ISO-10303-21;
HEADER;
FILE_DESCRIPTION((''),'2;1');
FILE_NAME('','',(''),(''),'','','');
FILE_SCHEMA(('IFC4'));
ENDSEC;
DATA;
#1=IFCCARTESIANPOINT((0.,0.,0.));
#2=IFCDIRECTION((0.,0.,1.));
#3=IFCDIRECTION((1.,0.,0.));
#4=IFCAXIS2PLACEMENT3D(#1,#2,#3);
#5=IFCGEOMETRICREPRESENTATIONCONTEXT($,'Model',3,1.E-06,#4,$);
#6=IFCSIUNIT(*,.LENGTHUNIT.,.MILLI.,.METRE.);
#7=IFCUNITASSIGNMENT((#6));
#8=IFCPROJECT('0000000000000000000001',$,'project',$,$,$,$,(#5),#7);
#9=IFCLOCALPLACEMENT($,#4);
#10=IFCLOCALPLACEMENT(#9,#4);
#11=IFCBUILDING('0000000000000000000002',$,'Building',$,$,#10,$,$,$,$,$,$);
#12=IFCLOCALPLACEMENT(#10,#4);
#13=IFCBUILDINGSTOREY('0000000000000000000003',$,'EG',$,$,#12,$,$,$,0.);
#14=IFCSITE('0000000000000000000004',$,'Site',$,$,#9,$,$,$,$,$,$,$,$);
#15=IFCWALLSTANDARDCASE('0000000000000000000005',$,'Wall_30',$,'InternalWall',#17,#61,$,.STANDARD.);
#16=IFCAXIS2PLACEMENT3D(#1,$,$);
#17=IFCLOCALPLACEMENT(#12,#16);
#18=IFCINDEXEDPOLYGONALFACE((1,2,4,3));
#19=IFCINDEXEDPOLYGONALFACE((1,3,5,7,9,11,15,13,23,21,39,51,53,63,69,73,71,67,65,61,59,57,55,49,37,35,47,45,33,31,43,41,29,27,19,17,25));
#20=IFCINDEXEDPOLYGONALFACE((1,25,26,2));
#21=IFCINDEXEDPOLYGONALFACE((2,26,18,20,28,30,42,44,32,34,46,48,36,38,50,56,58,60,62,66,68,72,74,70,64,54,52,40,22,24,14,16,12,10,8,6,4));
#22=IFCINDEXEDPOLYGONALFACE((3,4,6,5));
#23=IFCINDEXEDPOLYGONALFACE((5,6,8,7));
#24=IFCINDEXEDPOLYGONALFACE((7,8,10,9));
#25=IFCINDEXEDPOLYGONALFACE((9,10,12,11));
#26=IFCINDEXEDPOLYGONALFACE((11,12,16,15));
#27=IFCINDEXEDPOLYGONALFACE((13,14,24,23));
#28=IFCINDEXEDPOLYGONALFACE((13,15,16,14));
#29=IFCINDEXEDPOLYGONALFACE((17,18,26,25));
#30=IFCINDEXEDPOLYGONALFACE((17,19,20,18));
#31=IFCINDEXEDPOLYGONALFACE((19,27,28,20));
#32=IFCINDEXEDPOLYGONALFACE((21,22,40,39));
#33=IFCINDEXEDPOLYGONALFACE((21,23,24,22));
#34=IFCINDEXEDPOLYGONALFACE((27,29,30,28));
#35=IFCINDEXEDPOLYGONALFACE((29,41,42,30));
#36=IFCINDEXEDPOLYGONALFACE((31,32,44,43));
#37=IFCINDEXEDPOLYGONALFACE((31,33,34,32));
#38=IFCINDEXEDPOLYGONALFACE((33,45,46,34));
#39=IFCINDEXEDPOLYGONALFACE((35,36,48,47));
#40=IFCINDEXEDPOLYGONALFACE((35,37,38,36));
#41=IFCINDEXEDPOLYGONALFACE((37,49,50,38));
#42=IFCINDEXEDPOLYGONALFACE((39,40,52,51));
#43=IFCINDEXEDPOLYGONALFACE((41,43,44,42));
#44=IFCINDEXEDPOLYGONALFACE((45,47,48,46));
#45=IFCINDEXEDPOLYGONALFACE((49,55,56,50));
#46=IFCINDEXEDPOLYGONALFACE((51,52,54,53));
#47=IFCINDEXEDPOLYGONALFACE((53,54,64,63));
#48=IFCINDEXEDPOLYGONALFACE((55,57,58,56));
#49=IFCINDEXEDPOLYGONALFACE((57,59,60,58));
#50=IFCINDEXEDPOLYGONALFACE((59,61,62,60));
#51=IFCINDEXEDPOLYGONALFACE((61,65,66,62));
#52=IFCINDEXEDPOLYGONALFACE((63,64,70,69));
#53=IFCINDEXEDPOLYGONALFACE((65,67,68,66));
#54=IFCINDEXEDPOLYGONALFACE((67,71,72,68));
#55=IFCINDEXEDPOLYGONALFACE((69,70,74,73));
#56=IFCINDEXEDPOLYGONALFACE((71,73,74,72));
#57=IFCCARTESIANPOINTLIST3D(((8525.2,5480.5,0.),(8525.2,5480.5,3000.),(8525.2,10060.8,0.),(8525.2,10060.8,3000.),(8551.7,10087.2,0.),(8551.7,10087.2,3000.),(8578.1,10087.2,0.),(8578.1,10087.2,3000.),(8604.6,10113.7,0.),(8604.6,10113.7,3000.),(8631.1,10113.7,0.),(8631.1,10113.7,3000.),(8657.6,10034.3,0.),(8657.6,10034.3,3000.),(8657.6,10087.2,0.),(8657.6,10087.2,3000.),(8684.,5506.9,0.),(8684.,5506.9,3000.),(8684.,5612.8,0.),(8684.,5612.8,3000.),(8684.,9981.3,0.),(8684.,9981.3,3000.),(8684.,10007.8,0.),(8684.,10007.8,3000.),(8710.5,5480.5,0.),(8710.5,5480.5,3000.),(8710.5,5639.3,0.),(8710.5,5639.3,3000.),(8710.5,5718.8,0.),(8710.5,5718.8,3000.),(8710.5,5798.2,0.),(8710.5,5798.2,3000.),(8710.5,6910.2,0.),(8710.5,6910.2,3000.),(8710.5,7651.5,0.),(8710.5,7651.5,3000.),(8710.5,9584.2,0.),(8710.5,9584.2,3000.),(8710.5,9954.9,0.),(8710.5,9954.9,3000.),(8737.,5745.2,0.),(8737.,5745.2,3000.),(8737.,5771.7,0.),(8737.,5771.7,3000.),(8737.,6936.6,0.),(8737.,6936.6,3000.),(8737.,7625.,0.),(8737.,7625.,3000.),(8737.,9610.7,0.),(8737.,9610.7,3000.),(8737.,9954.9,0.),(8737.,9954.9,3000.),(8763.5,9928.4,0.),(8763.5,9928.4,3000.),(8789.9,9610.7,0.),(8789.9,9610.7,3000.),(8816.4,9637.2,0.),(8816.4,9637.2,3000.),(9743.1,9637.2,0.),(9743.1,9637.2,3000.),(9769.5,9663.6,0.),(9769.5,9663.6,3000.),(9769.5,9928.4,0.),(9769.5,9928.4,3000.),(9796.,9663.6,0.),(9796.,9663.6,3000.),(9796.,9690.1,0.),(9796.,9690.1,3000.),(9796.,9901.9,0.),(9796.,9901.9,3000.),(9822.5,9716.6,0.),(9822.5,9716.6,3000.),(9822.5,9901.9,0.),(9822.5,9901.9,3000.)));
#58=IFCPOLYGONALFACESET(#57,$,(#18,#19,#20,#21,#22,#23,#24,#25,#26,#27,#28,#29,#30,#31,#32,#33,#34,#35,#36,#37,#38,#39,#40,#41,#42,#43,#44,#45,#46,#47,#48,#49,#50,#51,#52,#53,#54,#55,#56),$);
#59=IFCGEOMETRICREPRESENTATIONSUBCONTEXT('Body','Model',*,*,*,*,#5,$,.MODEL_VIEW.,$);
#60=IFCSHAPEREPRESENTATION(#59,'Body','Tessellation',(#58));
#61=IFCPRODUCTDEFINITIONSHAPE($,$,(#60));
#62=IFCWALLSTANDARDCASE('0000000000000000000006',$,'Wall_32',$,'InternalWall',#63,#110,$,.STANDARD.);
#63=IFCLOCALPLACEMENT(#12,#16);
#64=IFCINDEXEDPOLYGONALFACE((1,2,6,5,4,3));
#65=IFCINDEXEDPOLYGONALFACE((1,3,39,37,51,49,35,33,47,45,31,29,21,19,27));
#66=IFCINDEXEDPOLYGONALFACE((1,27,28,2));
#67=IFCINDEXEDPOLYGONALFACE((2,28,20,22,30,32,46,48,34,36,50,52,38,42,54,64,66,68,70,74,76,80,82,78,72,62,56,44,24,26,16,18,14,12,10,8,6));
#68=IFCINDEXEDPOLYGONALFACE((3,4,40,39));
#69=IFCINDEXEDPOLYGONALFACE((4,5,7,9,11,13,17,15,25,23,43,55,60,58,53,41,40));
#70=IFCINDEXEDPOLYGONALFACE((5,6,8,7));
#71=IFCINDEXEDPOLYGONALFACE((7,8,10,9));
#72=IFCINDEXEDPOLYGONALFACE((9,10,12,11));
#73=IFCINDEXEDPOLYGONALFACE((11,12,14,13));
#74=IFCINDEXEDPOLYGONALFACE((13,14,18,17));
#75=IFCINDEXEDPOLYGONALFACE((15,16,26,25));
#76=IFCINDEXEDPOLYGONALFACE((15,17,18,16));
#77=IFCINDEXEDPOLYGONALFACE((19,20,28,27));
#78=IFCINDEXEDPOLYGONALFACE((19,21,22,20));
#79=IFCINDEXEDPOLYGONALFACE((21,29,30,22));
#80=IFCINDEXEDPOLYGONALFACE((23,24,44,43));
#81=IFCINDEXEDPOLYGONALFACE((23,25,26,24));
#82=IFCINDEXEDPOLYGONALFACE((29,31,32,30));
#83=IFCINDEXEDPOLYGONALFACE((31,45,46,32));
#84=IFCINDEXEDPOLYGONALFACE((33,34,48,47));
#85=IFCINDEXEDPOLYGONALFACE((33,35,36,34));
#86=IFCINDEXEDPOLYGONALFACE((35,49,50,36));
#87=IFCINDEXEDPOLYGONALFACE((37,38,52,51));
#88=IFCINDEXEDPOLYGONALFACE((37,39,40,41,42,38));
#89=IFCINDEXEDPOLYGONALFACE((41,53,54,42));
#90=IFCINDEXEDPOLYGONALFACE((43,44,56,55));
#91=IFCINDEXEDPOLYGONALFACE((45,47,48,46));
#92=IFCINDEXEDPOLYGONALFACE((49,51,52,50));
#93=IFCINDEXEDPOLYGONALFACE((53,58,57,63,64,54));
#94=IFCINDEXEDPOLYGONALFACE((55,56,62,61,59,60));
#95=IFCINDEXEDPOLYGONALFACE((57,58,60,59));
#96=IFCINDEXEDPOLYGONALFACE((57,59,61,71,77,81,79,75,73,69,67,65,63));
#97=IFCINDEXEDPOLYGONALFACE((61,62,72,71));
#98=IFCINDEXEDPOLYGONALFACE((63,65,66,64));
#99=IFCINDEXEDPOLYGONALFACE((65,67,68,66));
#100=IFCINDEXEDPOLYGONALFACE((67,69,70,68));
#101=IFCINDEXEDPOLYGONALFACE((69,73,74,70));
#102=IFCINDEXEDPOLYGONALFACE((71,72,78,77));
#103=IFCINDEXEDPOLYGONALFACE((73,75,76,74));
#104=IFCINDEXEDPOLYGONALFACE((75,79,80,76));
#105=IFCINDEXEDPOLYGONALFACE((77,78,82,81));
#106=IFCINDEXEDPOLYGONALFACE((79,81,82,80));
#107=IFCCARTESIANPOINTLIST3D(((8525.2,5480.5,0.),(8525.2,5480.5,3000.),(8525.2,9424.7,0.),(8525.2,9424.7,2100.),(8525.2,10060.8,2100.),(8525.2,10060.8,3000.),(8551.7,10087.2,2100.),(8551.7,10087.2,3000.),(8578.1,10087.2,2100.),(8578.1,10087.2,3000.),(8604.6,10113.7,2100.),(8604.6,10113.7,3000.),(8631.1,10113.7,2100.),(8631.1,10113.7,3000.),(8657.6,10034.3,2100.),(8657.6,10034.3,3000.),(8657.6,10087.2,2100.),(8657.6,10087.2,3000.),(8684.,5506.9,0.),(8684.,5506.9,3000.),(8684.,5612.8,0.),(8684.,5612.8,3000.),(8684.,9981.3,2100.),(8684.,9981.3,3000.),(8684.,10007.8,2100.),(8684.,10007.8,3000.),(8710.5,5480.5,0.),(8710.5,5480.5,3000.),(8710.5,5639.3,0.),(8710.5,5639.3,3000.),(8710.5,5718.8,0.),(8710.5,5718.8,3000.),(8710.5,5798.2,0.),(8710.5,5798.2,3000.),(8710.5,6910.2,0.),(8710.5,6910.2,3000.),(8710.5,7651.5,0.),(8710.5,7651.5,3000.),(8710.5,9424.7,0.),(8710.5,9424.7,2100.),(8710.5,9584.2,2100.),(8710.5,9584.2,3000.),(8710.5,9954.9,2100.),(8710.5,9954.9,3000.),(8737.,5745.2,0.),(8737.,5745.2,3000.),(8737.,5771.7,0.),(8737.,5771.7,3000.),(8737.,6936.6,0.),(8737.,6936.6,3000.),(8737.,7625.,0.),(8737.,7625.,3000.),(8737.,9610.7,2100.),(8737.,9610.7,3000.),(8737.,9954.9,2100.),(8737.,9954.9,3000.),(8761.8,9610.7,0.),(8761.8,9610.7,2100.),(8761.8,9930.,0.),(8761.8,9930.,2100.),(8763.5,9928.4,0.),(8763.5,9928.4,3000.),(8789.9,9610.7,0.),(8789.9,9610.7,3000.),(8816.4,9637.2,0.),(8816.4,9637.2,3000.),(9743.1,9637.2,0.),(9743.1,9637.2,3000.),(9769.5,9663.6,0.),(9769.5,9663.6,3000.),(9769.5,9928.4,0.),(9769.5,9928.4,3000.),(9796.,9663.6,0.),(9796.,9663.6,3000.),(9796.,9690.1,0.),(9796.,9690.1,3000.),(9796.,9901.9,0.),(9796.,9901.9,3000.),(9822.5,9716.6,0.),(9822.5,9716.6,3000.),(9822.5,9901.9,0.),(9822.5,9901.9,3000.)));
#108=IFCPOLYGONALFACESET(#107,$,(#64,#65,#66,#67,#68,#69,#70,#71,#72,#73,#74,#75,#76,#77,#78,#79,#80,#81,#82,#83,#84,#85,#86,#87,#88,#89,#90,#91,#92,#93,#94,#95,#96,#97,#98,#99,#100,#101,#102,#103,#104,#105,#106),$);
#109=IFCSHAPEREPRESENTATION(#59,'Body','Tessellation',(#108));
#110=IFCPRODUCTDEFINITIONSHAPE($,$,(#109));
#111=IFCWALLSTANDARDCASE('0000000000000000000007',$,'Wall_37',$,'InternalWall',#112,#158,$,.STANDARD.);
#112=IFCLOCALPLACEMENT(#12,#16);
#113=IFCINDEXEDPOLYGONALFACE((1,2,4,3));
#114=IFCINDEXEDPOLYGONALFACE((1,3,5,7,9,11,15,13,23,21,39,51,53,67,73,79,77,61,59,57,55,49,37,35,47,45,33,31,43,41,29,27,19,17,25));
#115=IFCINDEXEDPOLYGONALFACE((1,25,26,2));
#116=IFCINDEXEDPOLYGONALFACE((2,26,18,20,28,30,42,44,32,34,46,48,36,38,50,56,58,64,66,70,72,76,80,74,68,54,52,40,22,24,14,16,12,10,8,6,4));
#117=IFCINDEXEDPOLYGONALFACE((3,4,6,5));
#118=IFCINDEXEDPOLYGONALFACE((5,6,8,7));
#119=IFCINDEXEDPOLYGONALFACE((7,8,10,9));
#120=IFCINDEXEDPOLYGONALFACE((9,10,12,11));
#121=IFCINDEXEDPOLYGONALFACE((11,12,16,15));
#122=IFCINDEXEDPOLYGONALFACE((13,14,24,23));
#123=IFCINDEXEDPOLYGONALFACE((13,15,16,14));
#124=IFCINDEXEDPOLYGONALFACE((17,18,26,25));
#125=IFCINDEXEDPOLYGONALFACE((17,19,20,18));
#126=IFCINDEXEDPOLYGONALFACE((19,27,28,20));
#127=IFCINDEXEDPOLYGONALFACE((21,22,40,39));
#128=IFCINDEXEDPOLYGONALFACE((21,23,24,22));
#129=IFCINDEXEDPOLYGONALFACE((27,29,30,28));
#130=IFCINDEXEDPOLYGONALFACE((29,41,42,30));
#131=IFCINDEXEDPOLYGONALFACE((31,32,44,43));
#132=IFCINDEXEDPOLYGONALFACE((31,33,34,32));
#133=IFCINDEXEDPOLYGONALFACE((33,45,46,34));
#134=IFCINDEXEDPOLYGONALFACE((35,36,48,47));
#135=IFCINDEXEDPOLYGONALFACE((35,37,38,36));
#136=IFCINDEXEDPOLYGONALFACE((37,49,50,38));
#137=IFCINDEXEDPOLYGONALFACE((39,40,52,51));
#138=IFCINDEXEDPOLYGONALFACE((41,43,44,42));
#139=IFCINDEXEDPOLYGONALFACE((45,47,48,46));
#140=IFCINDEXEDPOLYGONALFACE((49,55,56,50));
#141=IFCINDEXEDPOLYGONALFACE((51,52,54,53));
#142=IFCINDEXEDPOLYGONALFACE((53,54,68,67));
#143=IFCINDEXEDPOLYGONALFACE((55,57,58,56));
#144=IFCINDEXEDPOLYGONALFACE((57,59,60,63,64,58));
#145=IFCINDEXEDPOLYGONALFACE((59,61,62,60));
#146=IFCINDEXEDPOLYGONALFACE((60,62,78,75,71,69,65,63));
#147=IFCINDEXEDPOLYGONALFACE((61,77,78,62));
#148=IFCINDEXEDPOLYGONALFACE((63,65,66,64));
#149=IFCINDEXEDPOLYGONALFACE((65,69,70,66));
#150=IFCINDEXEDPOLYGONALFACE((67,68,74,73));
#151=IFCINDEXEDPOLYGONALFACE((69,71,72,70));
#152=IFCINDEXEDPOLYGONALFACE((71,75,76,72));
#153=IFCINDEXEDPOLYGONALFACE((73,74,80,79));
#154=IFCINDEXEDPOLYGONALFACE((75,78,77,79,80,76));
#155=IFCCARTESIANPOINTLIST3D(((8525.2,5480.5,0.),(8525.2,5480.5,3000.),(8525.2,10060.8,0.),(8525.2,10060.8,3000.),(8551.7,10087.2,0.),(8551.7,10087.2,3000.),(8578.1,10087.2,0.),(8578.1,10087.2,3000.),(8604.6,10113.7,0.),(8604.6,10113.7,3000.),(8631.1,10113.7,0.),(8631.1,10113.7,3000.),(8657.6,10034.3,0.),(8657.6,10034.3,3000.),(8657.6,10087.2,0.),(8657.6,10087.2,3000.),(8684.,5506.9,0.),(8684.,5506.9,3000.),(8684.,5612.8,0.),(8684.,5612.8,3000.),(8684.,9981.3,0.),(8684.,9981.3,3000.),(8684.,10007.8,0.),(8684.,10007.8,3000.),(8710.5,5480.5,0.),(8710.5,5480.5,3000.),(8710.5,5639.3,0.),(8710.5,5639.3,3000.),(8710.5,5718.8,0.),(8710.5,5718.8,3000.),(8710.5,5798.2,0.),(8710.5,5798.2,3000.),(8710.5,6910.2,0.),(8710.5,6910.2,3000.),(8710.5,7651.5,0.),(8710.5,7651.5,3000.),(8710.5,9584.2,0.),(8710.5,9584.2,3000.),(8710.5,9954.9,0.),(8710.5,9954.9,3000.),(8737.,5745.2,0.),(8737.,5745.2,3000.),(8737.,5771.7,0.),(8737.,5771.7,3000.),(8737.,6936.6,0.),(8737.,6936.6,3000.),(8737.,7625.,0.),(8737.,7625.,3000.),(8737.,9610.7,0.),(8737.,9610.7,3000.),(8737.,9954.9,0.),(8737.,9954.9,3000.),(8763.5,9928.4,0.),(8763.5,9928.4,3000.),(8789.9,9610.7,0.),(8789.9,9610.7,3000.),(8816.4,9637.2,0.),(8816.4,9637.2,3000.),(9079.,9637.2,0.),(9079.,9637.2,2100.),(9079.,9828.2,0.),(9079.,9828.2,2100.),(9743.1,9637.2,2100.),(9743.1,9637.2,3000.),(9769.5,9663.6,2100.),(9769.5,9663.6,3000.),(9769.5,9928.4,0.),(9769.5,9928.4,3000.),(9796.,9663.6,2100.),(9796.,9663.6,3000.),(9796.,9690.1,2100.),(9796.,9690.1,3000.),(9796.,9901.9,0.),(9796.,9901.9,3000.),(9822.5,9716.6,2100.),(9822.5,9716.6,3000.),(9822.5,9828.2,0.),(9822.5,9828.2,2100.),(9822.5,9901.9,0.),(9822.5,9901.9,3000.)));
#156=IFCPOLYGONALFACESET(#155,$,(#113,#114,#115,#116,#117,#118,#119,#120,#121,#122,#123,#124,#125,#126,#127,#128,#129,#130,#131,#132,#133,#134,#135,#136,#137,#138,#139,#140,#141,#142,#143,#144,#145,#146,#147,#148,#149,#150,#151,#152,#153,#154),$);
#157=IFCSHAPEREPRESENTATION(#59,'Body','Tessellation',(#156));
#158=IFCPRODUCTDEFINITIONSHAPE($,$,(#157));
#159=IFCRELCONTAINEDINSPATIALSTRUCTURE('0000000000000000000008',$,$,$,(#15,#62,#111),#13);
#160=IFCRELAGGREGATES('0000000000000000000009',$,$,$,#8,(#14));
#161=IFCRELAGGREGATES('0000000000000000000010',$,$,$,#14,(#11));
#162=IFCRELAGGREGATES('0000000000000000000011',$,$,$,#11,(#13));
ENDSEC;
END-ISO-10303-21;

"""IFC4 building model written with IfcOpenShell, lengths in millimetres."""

from ifc_helpers import new_model, si_unit, frame, origin_with_axes, place, context, subcontext, project, spatial, polyline, rectangle, outline, extrude, element, save


model = new_model("IFC4")

# Units and contexts
model_context = context("Model", 3, precision=1e-06, world=origin_with_axes())
body_context = subcontext(model_context, "Body", "Model", "MODEL_VIEW")
ifc_project = project(units=[si_unit("LENGTHUNIT", "METRE", prefix="MILLI")], contexts=[model_context])

# Site, building, storey
site_placement = place(None, origin_with_axes())
site = spatial("IfcSite", under=ifc_project, at=site_placement, Name="Site")
building_placement = place(site_placement, origin_with_axes())
building = spatial("IfcBuilding", under=site, at=building_placement, Name="Building")
storey_placement = place(building_placement, origin_with_axes())
storey = spatial("IfcBuildingStorey", under=building, at=storey_placement, Name="EG", Elevation=0.0)

# Wall
for number, where, z_axis, x_axis, name in (
    (1, (0.0, 0.0, 0.0), (0.0, 0.0, 1.0), (1.0, 0.0, 0.0), "Wall_30"),
):
    element("IfcWallStandardCase", number, at=place(storey_placement, frame(where, z_axis=z_axis, x_axis=x_axis)), inside=storey, Name=name, ObjectType="InternalWall", PredefinedType="STANDARD", context=body_context, shape_type="SweptSolid", body=[
        extrude(outline(polyline([(8525.2, 5480.5, 0.0), (8525.2, 10060.8, 0.0), (8551.7, 10087.2, 0.0), (8578.1, 10087.2, 0.0), (8604.6, 10113.7, 0.0), (8631.1, 10113.7, 0.0), (8657.6, 10087.2, 0.0), (8657.6, 10034.3, 0.0), (8684.0, 10007.8, 0.0), (8684.0, 9981.3, 0.0), (8710.5, 9954.9, 0.0), (8737.0, 9954.9, 0.0), (8763.5, 9928.4, 0.0), (9769.5, 9928.4, 0.0), (9796.0, 9901.9, 0.0), (9822.5, 9901.9, 0.0), (9822.5, 9716.6, 0.0), (9796.0, 9690.1, 0.0), (9796.0, 9663.6, 0.0), (9769.5, 9663.6, 0.0), (9743.1, 9637.2, 0.0), (8816.4, 9637.2, 0.0), (8789.9, 9610.7, 0.0), (8737.0, 9610.7, 0.0), (8710.5, 9584.2, 0.0), (8710.5, 7651.5, 0.0), (8737.0, 7625.0, 0.0), (8737.0, 6936.6, 0.0), (8710.5, 6910.2, 0.0), (8710.5, 5798.2, 0.0), (8737.0, 5771.7, 0.0), (8737.0, 5745.2, 0.0), (8710.5, 5718.8, 0.0), (8710.5, 5639.3, 0.0), (8684.0, 5612.8, 0.0), (8684.0, 5506.9, 0.0), (8710.5, 5480.5, 0.0), (8525.2, 5480.5, 0.0)])), origin_with_axes(), (0.0, 0.0, 1.0), 3000.0),
    ])

# Wall, opening
wall_1_placement = place(storey_placement, origin_with_axes())
wall_1 = element("IfcWallStandardCase", 2, at=wall_1_placement, inside=storey, Name="Wall_32", ObjectType="InternalWall", PredefinedType="STANDARD", context=body_context, shape_type="SweptSolid", body=[
    extrude(outline(polyline([(8525.2, 5480.5, 0.0), (8525.2, 10060.8, 0.0), (8551.7, 10087.2, 0.0), (8578.1, 10087.2, 0.0), (8604.6, 10113.7, 0.0), (8631.1, 10113.7, 0.0), (8657.6, 10087.2, 0.0), (8657.6, 10034.3, 0.0), (8684.0, 10007.8, 0.0), (8684.0, 9981.3, 0.0), (8710.5, 9954.9, 0.0), (8737.0, 9954.9, 0.0), (8763.5, 9928.4, 0.0), (9769.5, 9928.4, 0.0), (9796.0, 9901.9, 0.0), (9822.5, 9901.9, 0.0), (9822.5, 9716.6, 0.0), (9796.0, 9690.1, 0.0), (9796.0, 9663.6, 0.0), (9769.5, 9663.6, 0.0), (9743.1, 9637.2, 0.0), (8816.4, 9637.2, 0.0), (8789.9, 9610.7, 0.0), (8737.0, 9610.7, 0.0), (8710.5, 9584.2, 0.0), (8710.5, 7651.5, 0.0), (8737.0, 7625.0, 0.0), (8737.0, 6936.6, 0.0), (8710.5, 6910.2, 0.0), (8710.5, 5798.2, 0.0), (8737.0, 5771.7, 0.0), (8737.0, 5745.2, 0.0), (8710.5, 5718.8, 0.0), (8710.5, 5639.3, 0.0), (8684.0, 5612.8, 0.0), (8684.0, 5506.9, 0.0), (8710.5, 5480.5, 0.0), (8525.2, 5480.5, 0.0)])), origin_with_axes(), (0.0, 0.0, 1.0), 3000.0),
])
opening_1_placement = place(wall_1_placement, origin_with_axes())
element("IfcOpeningElement", 3, at=opening_1_placement, inside=storey, cuts=wall_1, context=body_context, shape_type="SweptSolid", body=[
    extrude(rectangle(XDim=1344.8, YDim=240.0), frame((8641.8, 10097.1, 0.0), z_axis=(0.0, 0.0, 1.0), x_axis=(0.0, 1.0, 0.0)), (0.0, 0.0, 1.0), 2100.0),
])

# Wall, opening
wall_2_placement = place(storey_placement, origin_with_axes())
wall_2 = element("IfcWallStandardCase", 4, at=wall_2_placement, inside=storey, Name="Wall_37", ObjectType="InternalWall", PredefinedType="STANDARD", context=body_context, shape_type="SweptSolid", body=[
    extrude(outline(polyline([(8525.2, 5480.5, 0.0), (8525.2, 10060.8, 0.0), (8551.7, 10087.2, 0.0), (8578.1, 10087.2, 0.0), (8604.6, 10113.7, 0.0), (8631.1, 10113.7, 0.0), (8657.6, 10087.2, 0.0), (8657.6, 10034.3, 0.0), (8684.0, 10007.8, 0.0), (8684.0, 9981.3, 0.0), (8710.5, 9954.9, 0.0), (8737.0, 9954.9, 0.0), (8763.5, 9928.4, 0.0), (9769.5, 9928.4, 0.0), (9796.0, 9901.9, 0.0), (9822.5, 9901.9, 0.0), (9822.5, 9716.6, 0.0), (9796.0, 9690.1, 0.0), (9796.0, 9663.6, 0.0), (9769.5, 9663.6, 0.0), (9743.1, 9637.2, 0.0), (8816.4, 9637.2, 0.0), (8789.9, 9610.7, 0.0), (8737.0, 9610.7, 0.0), (8710.5, 9584.2, 0.0), (8710.5, 7651.5, 0.0), (8737.0, 7625.0, 0.0), (8737.0, 6936.6, 0.0), (8710.5, 6910.2, 0.0), (8710.5, 5798.2, 0.0), (8737.0, 5771.7, 0.0), (8737.0, 5745.2, 0.0), (8710.5, 5718.8, 0.0), (8710.5, 5639.3, 0.0), (8684.0, 5612.8, 0.0), (8684.0, 5506.9, 0.0), (8710.5, 5480.5, 0.0), (8525.2, 5480.5, 0.0)])), origin_with_axes(), (0.0, 0.0, 1.0), 3000.0),
])
opening_2_placement = place(wall_2_placement, origin_with_axes())
element("IfcOpeningElement", 5, at=opening_2_placement, inside=storey, cuts=wall_2, context=body_context, shape_type="SweptSolid", body=[
    extrude(rectangle(XDim=1347.9, YDim=240.0), frame((9753.0, 9708.2, 0.0), z_axis=(0.0, 0.0, 1.0), x_axis=(1.0, 0.0, 0.0)), (0.0, 0.0, 1.0), 2100.0),
])

save(model, "model.ifc")
